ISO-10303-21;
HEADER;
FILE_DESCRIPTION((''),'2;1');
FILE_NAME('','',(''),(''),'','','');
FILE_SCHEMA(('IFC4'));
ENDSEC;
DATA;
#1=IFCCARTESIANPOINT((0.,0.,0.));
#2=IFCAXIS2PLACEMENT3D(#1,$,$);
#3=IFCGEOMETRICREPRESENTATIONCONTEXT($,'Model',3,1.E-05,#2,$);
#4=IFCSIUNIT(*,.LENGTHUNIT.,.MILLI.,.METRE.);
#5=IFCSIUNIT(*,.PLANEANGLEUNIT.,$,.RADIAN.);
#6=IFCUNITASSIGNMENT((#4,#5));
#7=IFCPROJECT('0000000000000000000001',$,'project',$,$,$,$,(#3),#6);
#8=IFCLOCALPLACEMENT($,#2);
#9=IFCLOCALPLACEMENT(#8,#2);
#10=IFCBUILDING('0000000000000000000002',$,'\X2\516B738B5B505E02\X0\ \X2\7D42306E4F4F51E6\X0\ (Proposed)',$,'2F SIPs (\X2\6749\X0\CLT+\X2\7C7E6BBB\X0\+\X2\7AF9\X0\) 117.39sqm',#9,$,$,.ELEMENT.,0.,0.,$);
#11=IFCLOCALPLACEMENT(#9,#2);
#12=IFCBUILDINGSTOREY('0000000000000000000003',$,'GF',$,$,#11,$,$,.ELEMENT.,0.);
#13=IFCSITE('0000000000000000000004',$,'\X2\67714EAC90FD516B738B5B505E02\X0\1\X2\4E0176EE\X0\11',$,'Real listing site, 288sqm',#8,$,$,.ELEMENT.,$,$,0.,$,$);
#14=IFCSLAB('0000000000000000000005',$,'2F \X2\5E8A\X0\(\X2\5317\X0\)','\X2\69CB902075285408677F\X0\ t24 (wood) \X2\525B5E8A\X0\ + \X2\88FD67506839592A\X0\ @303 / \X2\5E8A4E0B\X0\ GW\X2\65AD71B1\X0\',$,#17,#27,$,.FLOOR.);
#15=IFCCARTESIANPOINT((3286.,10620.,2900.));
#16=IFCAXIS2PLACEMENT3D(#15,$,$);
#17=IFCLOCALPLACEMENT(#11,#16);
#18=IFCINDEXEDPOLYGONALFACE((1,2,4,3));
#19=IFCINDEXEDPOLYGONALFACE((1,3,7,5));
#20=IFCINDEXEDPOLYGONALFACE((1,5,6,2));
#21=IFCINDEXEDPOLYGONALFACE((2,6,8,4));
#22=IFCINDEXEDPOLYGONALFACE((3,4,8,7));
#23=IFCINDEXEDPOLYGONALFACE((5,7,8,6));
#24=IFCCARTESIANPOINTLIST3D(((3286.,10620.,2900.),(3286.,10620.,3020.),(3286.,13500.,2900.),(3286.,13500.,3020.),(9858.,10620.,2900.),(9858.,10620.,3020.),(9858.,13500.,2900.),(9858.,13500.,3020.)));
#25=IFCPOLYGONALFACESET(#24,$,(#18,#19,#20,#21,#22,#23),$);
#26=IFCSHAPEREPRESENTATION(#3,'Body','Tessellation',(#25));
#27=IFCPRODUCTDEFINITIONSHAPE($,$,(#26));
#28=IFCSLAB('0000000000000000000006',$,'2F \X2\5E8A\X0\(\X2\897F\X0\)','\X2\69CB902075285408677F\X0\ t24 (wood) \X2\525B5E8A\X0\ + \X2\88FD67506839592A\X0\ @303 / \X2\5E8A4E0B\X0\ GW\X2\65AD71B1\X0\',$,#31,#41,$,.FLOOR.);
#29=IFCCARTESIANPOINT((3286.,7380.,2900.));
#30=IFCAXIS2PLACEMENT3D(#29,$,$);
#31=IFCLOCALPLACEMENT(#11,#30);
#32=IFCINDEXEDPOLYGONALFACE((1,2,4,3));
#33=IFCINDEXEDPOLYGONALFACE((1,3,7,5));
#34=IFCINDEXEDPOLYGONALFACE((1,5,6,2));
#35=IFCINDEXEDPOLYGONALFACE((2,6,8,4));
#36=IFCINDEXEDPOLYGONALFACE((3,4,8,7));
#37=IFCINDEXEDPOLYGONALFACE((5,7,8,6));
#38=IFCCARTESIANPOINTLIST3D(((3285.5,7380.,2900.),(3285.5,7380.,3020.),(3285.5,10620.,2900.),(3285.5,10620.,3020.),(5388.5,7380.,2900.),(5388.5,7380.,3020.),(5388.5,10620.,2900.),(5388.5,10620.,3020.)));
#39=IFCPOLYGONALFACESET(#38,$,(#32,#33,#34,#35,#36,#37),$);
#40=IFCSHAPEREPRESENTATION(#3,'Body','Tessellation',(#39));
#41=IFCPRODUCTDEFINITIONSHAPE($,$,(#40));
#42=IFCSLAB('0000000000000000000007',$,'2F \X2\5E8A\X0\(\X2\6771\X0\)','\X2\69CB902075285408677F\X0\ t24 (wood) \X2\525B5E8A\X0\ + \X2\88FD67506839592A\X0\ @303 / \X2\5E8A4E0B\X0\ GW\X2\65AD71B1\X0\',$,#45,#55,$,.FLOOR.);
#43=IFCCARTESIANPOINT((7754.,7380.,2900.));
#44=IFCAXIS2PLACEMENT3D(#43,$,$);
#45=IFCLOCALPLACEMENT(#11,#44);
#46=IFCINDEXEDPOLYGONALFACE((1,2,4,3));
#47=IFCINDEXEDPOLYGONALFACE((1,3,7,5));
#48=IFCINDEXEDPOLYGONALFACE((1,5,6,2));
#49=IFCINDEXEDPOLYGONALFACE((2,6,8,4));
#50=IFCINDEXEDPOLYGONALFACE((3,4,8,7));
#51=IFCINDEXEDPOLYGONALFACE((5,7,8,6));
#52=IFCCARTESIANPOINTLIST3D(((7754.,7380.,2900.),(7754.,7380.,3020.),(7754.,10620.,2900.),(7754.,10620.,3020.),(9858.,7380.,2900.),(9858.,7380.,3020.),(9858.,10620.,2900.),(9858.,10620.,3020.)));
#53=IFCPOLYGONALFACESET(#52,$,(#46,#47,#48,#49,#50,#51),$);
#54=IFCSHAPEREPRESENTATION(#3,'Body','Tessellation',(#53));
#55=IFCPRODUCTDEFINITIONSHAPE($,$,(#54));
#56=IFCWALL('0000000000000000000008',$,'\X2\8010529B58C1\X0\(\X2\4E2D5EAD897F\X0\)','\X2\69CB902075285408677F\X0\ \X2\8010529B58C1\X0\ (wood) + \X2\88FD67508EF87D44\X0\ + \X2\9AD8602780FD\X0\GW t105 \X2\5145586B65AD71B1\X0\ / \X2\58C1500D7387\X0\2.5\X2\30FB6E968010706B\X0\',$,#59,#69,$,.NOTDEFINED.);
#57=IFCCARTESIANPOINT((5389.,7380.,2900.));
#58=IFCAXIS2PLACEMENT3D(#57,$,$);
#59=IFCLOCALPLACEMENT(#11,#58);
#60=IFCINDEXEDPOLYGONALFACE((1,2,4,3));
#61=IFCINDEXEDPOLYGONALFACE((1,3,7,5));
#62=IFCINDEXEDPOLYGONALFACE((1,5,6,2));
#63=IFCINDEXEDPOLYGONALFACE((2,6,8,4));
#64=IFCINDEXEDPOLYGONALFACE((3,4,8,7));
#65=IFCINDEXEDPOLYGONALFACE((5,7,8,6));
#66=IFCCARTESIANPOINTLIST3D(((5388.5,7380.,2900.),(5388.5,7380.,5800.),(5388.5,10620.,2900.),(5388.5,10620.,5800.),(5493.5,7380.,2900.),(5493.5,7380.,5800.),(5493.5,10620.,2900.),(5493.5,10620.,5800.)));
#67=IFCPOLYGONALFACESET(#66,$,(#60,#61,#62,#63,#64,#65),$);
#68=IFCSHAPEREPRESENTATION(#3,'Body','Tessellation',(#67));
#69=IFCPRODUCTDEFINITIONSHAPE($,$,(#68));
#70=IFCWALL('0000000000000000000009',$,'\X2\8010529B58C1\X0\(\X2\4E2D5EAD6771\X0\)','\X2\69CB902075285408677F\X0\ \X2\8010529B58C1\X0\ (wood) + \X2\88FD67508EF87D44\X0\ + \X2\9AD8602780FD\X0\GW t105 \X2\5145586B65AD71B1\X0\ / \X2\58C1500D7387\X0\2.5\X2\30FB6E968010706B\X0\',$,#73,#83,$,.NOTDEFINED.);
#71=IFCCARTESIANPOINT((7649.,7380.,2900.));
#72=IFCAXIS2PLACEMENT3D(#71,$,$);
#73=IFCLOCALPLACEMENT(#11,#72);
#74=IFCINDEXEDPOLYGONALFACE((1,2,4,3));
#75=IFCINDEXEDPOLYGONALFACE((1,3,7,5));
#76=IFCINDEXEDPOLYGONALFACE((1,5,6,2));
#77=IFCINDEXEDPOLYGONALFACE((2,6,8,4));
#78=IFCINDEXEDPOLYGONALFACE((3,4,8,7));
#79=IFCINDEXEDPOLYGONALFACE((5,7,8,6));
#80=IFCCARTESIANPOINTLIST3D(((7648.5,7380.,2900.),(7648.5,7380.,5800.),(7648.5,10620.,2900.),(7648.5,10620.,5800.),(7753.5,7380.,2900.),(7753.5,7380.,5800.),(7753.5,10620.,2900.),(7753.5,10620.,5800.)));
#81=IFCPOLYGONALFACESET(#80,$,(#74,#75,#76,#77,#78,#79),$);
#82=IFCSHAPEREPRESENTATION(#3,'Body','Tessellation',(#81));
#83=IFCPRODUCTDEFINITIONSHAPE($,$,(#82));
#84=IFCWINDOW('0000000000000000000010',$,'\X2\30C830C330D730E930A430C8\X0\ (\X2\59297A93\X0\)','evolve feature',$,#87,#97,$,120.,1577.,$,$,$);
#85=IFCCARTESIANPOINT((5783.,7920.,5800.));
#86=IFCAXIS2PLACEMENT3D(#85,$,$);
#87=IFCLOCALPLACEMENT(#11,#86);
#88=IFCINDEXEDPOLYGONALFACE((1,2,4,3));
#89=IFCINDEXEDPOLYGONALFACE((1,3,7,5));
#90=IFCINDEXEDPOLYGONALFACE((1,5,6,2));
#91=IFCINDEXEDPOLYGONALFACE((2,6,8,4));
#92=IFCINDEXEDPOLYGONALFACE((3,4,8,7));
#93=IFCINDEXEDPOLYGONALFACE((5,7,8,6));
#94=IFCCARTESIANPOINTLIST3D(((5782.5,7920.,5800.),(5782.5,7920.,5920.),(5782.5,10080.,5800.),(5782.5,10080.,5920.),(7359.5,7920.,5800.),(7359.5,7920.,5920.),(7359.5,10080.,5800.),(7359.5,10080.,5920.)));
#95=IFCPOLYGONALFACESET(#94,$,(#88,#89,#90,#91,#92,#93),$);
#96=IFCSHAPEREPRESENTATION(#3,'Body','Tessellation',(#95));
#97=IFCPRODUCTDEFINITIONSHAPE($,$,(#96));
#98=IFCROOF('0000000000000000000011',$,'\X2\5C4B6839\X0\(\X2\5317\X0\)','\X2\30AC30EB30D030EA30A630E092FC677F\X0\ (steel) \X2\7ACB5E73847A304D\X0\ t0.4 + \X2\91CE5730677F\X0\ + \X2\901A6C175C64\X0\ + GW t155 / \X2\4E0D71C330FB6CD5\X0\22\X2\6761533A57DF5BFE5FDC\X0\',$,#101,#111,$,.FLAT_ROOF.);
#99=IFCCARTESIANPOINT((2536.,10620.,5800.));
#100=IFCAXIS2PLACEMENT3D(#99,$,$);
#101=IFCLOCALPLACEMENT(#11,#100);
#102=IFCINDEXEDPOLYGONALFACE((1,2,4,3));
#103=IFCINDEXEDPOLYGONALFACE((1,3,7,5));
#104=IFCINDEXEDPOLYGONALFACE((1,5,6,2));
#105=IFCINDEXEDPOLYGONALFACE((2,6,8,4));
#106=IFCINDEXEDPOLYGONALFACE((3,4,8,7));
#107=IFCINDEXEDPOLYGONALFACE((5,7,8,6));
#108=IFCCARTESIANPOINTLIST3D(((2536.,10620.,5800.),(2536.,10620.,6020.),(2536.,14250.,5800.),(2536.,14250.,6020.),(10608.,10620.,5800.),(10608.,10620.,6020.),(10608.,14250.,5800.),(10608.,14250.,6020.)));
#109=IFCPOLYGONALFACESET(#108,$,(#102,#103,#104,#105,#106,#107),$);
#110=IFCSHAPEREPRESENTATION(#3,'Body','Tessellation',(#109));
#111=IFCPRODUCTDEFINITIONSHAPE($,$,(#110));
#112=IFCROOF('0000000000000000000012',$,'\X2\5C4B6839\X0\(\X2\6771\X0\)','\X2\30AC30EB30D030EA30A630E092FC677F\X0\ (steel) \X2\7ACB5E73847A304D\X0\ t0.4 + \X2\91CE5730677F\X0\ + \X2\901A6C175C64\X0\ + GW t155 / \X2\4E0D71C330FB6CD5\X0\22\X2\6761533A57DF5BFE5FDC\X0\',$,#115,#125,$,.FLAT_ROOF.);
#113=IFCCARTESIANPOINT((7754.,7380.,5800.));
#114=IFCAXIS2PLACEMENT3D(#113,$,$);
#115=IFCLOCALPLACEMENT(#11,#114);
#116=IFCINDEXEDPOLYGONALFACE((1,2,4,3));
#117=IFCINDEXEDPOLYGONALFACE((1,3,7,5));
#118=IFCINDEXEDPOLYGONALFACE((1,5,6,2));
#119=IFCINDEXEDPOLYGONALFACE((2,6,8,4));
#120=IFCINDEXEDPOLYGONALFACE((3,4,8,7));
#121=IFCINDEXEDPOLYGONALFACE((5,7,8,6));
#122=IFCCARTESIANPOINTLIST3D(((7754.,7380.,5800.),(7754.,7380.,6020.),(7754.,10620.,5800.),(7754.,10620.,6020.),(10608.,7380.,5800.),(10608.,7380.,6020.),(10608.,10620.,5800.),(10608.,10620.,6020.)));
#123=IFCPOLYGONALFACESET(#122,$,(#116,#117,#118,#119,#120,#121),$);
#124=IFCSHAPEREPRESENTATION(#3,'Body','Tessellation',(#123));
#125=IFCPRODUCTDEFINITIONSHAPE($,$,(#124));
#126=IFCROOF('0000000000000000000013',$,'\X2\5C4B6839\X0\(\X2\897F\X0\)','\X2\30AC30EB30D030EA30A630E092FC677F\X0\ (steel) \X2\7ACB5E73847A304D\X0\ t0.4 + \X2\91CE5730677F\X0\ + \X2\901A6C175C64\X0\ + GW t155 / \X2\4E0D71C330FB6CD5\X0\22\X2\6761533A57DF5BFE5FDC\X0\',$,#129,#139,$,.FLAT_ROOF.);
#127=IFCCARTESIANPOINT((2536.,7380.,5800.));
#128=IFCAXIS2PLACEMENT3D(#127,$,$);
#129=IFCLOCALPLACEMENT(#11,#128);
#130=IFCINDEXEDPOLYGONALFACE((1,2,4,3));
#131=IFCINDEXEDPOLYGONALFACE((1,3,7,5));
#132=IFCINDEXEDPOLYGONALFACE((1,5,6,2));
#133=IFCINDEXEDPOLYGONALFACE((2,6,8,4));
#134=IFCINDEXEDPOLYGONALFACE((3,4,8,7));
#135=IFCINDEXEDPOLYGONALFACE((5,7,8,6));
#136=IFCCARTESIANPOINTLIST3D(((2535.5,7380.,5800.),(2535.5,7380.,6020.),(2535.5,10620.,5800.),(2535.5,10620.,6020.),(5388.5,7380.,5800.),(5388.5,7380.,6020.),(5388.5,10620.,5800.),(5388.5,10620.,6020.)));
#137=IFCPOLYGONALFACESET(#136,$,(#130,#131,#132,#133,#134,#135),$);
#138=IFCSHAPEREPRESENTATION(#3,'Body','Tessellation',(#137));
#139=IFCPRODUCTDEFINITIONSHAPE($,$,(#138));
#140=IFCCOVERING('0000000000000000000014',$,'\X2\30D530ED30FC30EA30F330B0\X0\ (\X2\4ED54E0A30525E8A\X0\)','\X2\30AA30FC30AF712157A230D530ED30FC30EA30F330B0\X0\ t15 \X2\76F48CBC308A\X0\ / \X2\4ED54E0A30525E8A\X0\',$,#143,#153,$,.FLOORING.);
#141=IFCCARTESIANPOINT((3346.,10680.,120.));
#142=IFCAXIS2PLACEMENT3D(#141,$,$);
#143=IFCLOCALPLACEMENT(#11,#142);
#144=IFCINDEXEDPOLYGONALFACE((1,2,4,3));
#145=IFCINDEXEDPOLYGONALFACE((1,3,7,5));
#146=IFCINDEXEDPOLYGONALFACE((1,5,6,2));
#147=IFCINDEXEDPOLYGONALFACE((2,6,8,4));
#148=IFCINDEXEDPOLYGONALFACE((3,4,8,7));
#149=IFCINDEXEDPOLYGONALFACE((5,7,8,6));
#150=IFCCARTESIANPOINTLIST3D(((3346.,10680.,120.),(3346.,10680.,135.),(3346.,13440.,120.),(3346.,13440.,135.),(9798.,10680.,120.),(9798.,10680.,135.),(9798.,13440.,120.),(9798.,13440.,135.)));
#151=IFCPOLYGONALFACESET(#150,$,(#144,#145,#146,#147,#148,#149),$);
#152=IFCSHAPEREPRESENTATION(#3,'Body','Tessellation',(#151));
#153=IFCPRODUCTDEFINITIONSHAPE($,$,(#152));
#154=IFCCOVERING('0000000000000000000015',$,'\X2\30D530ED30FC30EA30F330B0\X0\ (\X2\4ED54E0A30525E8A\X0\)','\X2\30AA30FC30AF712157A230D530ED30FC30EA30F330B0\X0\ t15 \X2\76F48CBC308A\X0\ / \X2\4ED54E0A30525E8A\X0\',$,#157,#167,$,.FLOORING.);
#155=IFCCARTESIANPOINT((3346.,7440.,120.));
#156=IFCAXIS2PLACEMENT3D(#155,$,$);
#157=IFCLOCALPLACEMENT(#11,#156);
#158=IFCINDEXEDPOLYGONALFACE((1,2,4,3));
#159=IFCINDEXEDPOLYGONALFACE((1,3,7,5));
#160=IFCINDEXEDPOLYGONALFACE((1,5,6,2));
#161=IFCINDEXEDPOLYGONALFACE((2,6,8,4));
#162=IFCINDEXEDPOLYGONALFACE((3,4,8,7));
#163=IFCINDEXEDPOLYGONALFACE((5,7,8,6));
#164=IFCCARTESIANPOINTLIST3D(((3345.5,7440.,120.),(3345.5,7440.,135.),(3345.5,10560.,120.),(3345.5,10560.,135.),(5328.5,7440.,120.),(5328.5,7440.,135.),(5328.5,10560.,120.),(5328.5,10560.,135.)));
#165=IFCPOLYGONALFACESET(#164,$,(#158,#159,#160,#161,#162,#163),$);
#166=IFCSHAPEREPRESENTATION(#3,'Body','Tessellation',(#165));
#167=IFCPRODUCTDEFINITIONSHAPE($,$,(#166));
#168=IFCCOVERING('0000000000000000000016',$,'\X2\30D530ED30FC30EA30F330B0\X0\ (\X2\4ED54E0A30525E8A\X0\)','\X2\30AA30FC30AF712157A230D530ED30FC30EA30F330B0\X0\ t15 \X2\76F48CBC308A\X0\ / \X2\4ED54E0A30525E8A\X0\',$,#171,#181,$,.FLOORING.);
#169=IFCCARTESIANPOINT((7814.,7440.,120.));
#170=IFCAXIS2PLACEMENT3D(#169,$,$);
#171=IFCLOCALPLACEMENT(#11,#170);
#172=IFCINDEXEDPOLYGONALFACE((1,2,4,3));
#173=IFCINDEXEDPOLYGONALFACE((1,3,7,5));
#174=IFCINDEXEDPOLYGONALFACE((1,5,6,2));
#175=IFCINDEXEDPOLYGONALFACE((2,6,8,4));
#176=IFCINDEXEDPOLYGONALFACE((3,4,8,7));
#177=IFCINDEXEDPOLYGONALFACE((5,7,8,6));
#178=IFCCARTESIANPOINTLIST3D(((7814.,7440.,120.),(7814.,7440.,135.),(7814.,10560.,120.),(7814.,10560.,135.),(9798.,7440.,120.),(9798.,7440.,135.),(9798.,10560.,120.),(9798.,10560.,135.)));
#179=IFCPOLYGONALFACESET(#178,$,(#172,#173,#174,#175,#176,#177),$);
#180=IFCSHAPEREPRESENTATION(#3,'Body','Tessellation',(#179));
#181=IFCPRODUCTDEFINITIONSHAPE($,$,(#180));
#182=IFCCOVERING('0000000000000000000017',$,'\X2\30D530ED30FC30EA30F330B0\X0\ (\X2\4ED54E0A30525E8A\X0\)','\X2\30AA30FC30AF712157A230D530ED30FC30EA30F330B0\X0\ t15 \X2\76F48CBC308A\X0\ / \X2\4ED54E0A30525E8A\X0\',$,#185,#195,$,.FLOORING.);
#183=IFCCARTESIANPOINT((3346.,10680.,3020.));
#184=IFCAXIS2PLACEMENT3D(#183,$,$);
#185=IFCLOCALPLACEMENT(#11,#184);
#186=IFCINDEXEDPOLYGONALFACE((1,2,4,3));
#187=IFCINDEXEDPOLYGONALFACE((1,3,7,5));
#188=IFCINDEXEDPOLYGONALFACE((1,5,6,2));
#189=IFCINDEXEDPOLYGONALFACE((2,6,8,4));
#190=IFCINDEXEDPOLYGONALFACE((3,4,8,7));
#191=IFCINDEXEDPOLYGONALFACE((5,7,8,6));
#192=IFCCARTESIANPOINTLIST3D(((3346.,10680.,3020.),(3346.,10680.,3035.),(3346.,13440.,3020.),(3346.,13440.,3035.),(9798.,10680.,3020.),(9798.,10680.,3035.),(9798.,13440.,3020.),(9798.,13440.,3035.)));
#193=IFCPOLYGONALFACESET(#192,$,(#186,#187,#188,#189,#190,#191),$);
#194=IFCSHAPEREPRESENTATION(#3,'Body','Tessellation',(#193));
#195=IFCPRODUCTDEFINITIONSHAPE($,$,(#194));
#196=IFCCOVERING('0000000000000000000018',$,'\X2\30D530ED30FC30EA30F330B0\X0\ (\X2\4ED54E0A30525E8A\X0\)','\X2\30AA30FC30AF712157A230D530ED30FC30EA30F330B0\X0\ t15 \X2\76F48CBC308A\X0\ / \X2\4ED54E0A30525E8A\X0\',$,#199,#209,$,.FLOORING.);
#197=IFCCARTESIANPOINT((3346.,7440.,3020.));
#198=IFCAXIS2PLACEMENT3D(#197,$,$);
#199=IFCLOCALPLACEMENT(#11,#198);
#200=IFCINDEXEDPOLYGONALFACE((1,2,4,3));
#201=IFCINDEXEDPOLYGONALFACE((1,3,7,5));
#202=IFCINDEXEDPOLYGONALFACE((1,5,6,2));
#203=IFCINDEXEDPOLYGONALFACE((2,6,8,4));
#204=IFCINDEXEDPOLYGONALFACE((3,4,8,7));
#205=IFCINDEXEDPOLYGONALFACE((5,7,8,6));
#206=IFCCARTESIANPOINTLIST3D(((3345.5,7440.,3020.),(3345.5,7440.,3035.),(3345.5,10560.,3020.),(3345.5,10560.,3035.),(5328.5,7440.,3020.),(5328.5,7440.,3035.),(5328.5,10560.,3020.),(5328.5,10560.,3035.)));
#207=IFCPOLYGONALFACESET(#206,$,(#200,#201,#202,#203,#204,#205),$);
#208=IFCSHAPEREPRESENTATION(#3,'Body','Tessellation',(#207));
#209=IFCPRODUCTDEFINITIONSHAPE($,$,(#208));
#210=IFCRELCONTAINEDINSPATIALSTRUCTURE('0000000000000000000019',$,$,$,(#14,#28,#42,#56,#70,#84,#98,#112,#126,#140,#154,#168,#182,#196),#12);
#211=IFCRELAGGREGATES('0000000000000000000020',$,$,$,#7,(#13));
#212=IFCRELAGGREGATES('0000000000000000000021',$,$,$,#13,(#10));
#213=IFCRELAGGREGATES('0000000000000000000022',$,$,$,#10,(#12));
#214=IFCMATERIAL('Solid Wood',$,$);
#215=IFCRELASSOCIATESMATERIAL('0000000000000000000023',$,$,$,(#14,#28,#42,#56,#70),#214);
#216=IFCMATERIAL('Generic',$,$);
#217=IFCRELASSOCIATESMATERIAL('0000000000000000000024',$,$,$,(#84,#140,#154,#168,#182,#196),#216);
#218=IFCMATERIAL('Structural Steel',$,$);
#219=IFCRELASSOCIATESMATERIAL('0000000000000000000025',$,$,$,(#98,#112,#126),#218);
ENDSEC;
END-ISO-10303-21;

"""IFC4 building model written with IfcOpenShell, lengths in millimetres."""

from ifc_helpers import new_model, si_unit, frame, frame_2d, origin, place, context, project, spatial, rectangle, extrude, material, element, save


model = new_model("IFC4")

# Units and contexts
model_context = context("Model", 3, precision=1e-05, world=origin())
ifc_project = project(units=[si_unit("LENGTHUNIT", "METRE", prefix="MILLI"), si_unit("PLANEANGLEUNIT", "RADIAN")], contexts=[model_context])

# Site, building, storey
site_placement = place(None, origin())
site = spatial("IfcSite", under=ifc_project, at=site_placement, Name="東京都八王子市1丁目11", ObjectType="Real listing site, 288sqm", CompositionType="ELEMENT", RefElevation=0.0)
building_placement = place(site_placement, origin())
building = spatial("IfcBuilding", under=site, at=building_placement, Name="八王子市 終の住処 (Proposed)", ObjectType="2F SIPs (杉CLT+籾殻+竹) 117.39sqm", CompositionType="ELEMENT", ElevationOfRefHeight=0.0, ElevationOfTerrain=0.0)
storey_placement = place(building_placement, origin())
storey = spatial("IfcBuildingStorey", under=building, at=storey_placement, Name="GF", CompositionType="ELEMENT", Elevation=0.0)

# Slabs
ifc_material_1 = material(Name="Solid Wood")
slab_1_placement = place(storey_placement, frame((3286.0, 10620.0, 2900.0)))
element("IfcSlab", 1, at=slab_1_placement, inside=storey, material=ifc_material_1, Name="2F 床(北)", Description="構造用合板 t24 (wood) 剛床 + 製材根太 @303 / 床下 GW断熱", PredefinedType="FLOOR", context=model_context, shape_type="SweptSolid", body=[
    extrude(rectangle(XDim=6572.0, YDim=2880.0, at=frame_2d((3286.0, 1440.0))), frame((3286.0, 10620.0, 2900.0)), (0.0, 0.0, 1.0), 120.0),
])
slab_2_placement = place(storey_placement, frame((3286.0, 7380.0, 2900.0)))
element("IfcSlab", 2, at=slab_2_placement, inside=storey, material=ifc_material_1, Name="2F 床(西)", Description="構造用合板 t24 (wood) 剛床 + 製材根太 @303 / 床下 GW断熱", PredefinedType="FLOOR", context=model_context, shape_type="SweptSolid", body=[
    extrude(rectangle(XDim=2103.0, YDim=3240.0, at=frame_2d((1051.0, 1620.0))), frame((3286.0, 7380.0, 2900.0)), (0.0, 0.0, 1.0), 120.0),
])
slab_3_placement = place(storey_placement, frame((7754.0, 7380.0, 2900.0)))
element("IfcSlab", 3, at=slab_3_placement, inside=storey, material=ifc_material_1, Name="2F 床(東)", Description="構造用合板 t24 (wood) 剛床 + 製材根太 @303 / 床下 GW断熱", PredefinedType="FLOOR", context=model_context, shape_type="SweptSolid", body=[
    extrude(rectangle(XDim=2104.0, YDim=3240.0, at=frame_2d((1052.0, 1620.0))), frame((7754.0, 7380.0, 2900.0)), (0.0, 0.0, 1.0), 120.0),
])

# Walls
wall_1_placement = place(storey_placement, frame((5389.0, 7380.0, 2900.0)))
element("IfcWall", 4, at=wall_1_placement, inside=storey, material=ifc_material_1, Name="耐力壁(中庭西)", Description="構造用合板 耐力壁 (wood) + 製材軸組 + 高性能GW t105 充填断熱 / 壁倍率2.5・準耐火", PredefinedType="NOTDEFINED", context=model_context, shape_type="SweptSolid", body=[
    extrude(rectangle(XDim=105.0, YDim=3240.0, at=frame_2d((52.0, 1620.0))), frame((5389.0, 7380.0, 2900.0)), (0.0, 0.0, 1.0), 2900.0),
])
wall_2_placement = place(storey_placement, frame((7649.0, 7380.0, 2900.0)))
element("IfcWall", 5, at=wall_2_placement, inside=storey, material=ifc_material_1, Name="耐力壁(中庭東)", Description="構造用合板 耐力壁 (wood) + 製材軸組 + 高性能GW t105 充填断熱 / 壁倍率2.5・準耐火", PredefinedType="NOTDEFINED", context=model_context, shape_type="SweptSolid", body=[
    extrude(rectangle(XDim=105.0, YDim=3240.0, at=frame_2d((52.0, 1620.0))), frame((7649.0, 7380.0, 2900.0)), (0.0, 0.0, 1.0), 2900.0),
])

# Window
ifc_material_2 = material(Name="Generic")
window_1_placement = place(storey_placement, frame((5783.0, 7920.0, 5800.0)))
element("IfcWindow", 6, at=window_1_placement, inside=storey, material=ifc_material_2, Name="トップライト (天窓)", Description="evolve feature", OverallHeight=120.0, OverallWidth=1577.0, context=model_context, shape_type="SweptSolid", body=[
    extrude(rectangle(XDim=1577.0, YDim=2160.0, at=frame_2d((788.0, 1080.0))), frame((5783.0, 7920.0, 5800.0)), (0.0, 0.0, 1.0), 120.0),
])

# Roofs
ifc_material_3 = material(Name="Structural Steel")
roof_1_placement = place(storey_placement, frame((2536.0, 10620.0, 5800.0)))
element("IfcRoof", 7, at=roof_1_placement, inside=storey, material=ifc_material_3, Name="屋根(北)", Description="ガルバリウム鋼板 (steel) 立平葺き t0.4 + 野地板 + 通気層 + GW t155 / 不燃・法22条区域対応", PredefinedType="FLAT_ROOF", context=model_context, shape_type="SweptSolid", body=[
    extrude(rectangle(XDim=8072.0, YDim=3630.0, at=frame_2d((4036.0, 1815.0))), frame((2536.0, 10620.0, 5800.0)), (0.0, 0.0, 1.0), 220.0),
])
roof_2_placement = place(storey_placement, frame((7754.0, 7380.0, 5800.0)))
element("IfcRoof", 8, at=roof_2_placement, inside=storey, material=ifc_material_3, Name="屋根(東)", Description="ガルバリウム鋼板 (steel) 立平葺き t0.4 + 野地板 + 通気層 + GW t155 / 不燃・法22条区域対応", PredefinedType="FLAT_ROOF", context=model_context, shape_type="SweptSolid", body=[
    extrude(rectangle(XDim=2854.0, YDim=3240.0, at=frame_2d((1427.0, 1620.0))), frame((7754.0, 7380.0, 5800.0)), (0.0, 0.0, 1.0), 220.0),
])
roof_3_placement = place(storey_placement, frame((2536.0, 7380.0, 5800.0)))
element("IfcRoof", 9, at=roof_3_placement, inside=storey, material=ifc_material_3, Name="屋根(西)", Description="ガルバリウム鋼板 (steel) 立平葺き t0.4 + 野地板 + 通気層 + GW t155 / 不燃・法22条区域対応", PredefinedType="FLAT_ROOF", context=model_context, shape_type="SweptSolid", body=[
    extrude(rectangle(XDim=2853.0, YDim=3240.0, at=frame_2d((1426.0, 1620.0))), frame((2536.0, 7380.0, 5800.0)), (0.0, 0.0, 1.0), 220.0),
])

# Coverings
covering_1_placement = place(storey_placement, frame((3346.0, 10680.0, 120.0)))
element("IfcCovering", 10, at=covering_1_placement, inside=storey, material=ifc_material_2, Name="フローリング (仕上げ床)", Description="オーク無垢フローリング t15 直貼り / 仕上げ床", PredefinedType="FLOORING", context=model_context, shape_type="SweptSolid", body=[
    extrude(rectangle(XDim=6452.0, YDim=2760.0, at=frame_2d((3226.0, 1380.0))), frame((3346.0, 10680.0, 120.0)), (0.0, 0.0, 1.0), 15.0),
])
covering_2_placement = place(storey_placement, frame((3346.0, 7440.0, 120.0)))
element("IfcCovering", 11, at=covering_2_placement, inside=storey, material=ifc_material_2, Name="フローリング (仕上げ床)", Description="オーク無垢フローリング t15 直貼り / 仕上げ床", PredefinedType="FLOORING", context=model_context, shape_type="SweptSolid", body=[
    extrude(rectangle(XDim=1983.0, YDim=3120.0, at=frame_2d((991.0, 1560.0))), frame((3346.0, 7440.0, 120.0)), (0.0, 0.0, 1.0), 15.0),
])
covering_3_placement = place(storey_placement, frame((7814.0, 7440.0, 120.0)))
element("IfcCovering", 12, at=covering_3_placement, inside=storey, material=ifc_material_2, Name="フローリング (仕上げ床)", Description="オーク無垢フローリング t15 直貼り / 仕上げ床", PredefinedType="FLOORING", context=model_context, shape_type="SweptSolid", body=[
    extrude(rectangle(XDim=1984.0, YDim=3120.0, at=frame_2d((992.0, 1560.0))), frame((7814.0, 7440.0, 120.0)), (0.0, 0.0, 1.0), 15.0),
])
covering_4_placement = place(storey_placement, frame((3346.0, 10680.0, 3020.0)))
element("IfcCovering", 13, at=covering_4_placement, inside=storey, material=ifc_material_2, Name="フローリング (仕上げ床)", Description="オーク無垢フローリング t15 直貼り / 仕上げ床", PredefinedType="FLOORING", context=model_context, shape_type="SweptSolid", body=[
    extrude(rectangle(XDim=6452.0, YDim=2760.0, at=frame_2d((3226.0, 1380.0))), frame((3346.0, 10680.0, 3020.0)), (0.0, 0.0, 1.0), 15.0),
])
covering_5_placement = place(storey_placement, frame((3346.0, 7440.0, 3020.0)))
element("IfcCovering", 14, at=covering_5_placement, inside=storey, material=ifc_material_2, Name="フローリング (仕上げ床)", Description="オーク無垢フローリング t15 直貼り / 仕上げ床", PredefinedType="FLOORING", context=model_context, shape_type="SweptSolid", body=[
    extrude(rectangle(XDim=1983.0, YDim=3120.0, at=frame_2d((991.0, 1560.0))), frame((3346.0, 7440.0, 3020.0)), (0.0, 0.0, 1.0), 15.0),
])

save(model, "model.ifc")
